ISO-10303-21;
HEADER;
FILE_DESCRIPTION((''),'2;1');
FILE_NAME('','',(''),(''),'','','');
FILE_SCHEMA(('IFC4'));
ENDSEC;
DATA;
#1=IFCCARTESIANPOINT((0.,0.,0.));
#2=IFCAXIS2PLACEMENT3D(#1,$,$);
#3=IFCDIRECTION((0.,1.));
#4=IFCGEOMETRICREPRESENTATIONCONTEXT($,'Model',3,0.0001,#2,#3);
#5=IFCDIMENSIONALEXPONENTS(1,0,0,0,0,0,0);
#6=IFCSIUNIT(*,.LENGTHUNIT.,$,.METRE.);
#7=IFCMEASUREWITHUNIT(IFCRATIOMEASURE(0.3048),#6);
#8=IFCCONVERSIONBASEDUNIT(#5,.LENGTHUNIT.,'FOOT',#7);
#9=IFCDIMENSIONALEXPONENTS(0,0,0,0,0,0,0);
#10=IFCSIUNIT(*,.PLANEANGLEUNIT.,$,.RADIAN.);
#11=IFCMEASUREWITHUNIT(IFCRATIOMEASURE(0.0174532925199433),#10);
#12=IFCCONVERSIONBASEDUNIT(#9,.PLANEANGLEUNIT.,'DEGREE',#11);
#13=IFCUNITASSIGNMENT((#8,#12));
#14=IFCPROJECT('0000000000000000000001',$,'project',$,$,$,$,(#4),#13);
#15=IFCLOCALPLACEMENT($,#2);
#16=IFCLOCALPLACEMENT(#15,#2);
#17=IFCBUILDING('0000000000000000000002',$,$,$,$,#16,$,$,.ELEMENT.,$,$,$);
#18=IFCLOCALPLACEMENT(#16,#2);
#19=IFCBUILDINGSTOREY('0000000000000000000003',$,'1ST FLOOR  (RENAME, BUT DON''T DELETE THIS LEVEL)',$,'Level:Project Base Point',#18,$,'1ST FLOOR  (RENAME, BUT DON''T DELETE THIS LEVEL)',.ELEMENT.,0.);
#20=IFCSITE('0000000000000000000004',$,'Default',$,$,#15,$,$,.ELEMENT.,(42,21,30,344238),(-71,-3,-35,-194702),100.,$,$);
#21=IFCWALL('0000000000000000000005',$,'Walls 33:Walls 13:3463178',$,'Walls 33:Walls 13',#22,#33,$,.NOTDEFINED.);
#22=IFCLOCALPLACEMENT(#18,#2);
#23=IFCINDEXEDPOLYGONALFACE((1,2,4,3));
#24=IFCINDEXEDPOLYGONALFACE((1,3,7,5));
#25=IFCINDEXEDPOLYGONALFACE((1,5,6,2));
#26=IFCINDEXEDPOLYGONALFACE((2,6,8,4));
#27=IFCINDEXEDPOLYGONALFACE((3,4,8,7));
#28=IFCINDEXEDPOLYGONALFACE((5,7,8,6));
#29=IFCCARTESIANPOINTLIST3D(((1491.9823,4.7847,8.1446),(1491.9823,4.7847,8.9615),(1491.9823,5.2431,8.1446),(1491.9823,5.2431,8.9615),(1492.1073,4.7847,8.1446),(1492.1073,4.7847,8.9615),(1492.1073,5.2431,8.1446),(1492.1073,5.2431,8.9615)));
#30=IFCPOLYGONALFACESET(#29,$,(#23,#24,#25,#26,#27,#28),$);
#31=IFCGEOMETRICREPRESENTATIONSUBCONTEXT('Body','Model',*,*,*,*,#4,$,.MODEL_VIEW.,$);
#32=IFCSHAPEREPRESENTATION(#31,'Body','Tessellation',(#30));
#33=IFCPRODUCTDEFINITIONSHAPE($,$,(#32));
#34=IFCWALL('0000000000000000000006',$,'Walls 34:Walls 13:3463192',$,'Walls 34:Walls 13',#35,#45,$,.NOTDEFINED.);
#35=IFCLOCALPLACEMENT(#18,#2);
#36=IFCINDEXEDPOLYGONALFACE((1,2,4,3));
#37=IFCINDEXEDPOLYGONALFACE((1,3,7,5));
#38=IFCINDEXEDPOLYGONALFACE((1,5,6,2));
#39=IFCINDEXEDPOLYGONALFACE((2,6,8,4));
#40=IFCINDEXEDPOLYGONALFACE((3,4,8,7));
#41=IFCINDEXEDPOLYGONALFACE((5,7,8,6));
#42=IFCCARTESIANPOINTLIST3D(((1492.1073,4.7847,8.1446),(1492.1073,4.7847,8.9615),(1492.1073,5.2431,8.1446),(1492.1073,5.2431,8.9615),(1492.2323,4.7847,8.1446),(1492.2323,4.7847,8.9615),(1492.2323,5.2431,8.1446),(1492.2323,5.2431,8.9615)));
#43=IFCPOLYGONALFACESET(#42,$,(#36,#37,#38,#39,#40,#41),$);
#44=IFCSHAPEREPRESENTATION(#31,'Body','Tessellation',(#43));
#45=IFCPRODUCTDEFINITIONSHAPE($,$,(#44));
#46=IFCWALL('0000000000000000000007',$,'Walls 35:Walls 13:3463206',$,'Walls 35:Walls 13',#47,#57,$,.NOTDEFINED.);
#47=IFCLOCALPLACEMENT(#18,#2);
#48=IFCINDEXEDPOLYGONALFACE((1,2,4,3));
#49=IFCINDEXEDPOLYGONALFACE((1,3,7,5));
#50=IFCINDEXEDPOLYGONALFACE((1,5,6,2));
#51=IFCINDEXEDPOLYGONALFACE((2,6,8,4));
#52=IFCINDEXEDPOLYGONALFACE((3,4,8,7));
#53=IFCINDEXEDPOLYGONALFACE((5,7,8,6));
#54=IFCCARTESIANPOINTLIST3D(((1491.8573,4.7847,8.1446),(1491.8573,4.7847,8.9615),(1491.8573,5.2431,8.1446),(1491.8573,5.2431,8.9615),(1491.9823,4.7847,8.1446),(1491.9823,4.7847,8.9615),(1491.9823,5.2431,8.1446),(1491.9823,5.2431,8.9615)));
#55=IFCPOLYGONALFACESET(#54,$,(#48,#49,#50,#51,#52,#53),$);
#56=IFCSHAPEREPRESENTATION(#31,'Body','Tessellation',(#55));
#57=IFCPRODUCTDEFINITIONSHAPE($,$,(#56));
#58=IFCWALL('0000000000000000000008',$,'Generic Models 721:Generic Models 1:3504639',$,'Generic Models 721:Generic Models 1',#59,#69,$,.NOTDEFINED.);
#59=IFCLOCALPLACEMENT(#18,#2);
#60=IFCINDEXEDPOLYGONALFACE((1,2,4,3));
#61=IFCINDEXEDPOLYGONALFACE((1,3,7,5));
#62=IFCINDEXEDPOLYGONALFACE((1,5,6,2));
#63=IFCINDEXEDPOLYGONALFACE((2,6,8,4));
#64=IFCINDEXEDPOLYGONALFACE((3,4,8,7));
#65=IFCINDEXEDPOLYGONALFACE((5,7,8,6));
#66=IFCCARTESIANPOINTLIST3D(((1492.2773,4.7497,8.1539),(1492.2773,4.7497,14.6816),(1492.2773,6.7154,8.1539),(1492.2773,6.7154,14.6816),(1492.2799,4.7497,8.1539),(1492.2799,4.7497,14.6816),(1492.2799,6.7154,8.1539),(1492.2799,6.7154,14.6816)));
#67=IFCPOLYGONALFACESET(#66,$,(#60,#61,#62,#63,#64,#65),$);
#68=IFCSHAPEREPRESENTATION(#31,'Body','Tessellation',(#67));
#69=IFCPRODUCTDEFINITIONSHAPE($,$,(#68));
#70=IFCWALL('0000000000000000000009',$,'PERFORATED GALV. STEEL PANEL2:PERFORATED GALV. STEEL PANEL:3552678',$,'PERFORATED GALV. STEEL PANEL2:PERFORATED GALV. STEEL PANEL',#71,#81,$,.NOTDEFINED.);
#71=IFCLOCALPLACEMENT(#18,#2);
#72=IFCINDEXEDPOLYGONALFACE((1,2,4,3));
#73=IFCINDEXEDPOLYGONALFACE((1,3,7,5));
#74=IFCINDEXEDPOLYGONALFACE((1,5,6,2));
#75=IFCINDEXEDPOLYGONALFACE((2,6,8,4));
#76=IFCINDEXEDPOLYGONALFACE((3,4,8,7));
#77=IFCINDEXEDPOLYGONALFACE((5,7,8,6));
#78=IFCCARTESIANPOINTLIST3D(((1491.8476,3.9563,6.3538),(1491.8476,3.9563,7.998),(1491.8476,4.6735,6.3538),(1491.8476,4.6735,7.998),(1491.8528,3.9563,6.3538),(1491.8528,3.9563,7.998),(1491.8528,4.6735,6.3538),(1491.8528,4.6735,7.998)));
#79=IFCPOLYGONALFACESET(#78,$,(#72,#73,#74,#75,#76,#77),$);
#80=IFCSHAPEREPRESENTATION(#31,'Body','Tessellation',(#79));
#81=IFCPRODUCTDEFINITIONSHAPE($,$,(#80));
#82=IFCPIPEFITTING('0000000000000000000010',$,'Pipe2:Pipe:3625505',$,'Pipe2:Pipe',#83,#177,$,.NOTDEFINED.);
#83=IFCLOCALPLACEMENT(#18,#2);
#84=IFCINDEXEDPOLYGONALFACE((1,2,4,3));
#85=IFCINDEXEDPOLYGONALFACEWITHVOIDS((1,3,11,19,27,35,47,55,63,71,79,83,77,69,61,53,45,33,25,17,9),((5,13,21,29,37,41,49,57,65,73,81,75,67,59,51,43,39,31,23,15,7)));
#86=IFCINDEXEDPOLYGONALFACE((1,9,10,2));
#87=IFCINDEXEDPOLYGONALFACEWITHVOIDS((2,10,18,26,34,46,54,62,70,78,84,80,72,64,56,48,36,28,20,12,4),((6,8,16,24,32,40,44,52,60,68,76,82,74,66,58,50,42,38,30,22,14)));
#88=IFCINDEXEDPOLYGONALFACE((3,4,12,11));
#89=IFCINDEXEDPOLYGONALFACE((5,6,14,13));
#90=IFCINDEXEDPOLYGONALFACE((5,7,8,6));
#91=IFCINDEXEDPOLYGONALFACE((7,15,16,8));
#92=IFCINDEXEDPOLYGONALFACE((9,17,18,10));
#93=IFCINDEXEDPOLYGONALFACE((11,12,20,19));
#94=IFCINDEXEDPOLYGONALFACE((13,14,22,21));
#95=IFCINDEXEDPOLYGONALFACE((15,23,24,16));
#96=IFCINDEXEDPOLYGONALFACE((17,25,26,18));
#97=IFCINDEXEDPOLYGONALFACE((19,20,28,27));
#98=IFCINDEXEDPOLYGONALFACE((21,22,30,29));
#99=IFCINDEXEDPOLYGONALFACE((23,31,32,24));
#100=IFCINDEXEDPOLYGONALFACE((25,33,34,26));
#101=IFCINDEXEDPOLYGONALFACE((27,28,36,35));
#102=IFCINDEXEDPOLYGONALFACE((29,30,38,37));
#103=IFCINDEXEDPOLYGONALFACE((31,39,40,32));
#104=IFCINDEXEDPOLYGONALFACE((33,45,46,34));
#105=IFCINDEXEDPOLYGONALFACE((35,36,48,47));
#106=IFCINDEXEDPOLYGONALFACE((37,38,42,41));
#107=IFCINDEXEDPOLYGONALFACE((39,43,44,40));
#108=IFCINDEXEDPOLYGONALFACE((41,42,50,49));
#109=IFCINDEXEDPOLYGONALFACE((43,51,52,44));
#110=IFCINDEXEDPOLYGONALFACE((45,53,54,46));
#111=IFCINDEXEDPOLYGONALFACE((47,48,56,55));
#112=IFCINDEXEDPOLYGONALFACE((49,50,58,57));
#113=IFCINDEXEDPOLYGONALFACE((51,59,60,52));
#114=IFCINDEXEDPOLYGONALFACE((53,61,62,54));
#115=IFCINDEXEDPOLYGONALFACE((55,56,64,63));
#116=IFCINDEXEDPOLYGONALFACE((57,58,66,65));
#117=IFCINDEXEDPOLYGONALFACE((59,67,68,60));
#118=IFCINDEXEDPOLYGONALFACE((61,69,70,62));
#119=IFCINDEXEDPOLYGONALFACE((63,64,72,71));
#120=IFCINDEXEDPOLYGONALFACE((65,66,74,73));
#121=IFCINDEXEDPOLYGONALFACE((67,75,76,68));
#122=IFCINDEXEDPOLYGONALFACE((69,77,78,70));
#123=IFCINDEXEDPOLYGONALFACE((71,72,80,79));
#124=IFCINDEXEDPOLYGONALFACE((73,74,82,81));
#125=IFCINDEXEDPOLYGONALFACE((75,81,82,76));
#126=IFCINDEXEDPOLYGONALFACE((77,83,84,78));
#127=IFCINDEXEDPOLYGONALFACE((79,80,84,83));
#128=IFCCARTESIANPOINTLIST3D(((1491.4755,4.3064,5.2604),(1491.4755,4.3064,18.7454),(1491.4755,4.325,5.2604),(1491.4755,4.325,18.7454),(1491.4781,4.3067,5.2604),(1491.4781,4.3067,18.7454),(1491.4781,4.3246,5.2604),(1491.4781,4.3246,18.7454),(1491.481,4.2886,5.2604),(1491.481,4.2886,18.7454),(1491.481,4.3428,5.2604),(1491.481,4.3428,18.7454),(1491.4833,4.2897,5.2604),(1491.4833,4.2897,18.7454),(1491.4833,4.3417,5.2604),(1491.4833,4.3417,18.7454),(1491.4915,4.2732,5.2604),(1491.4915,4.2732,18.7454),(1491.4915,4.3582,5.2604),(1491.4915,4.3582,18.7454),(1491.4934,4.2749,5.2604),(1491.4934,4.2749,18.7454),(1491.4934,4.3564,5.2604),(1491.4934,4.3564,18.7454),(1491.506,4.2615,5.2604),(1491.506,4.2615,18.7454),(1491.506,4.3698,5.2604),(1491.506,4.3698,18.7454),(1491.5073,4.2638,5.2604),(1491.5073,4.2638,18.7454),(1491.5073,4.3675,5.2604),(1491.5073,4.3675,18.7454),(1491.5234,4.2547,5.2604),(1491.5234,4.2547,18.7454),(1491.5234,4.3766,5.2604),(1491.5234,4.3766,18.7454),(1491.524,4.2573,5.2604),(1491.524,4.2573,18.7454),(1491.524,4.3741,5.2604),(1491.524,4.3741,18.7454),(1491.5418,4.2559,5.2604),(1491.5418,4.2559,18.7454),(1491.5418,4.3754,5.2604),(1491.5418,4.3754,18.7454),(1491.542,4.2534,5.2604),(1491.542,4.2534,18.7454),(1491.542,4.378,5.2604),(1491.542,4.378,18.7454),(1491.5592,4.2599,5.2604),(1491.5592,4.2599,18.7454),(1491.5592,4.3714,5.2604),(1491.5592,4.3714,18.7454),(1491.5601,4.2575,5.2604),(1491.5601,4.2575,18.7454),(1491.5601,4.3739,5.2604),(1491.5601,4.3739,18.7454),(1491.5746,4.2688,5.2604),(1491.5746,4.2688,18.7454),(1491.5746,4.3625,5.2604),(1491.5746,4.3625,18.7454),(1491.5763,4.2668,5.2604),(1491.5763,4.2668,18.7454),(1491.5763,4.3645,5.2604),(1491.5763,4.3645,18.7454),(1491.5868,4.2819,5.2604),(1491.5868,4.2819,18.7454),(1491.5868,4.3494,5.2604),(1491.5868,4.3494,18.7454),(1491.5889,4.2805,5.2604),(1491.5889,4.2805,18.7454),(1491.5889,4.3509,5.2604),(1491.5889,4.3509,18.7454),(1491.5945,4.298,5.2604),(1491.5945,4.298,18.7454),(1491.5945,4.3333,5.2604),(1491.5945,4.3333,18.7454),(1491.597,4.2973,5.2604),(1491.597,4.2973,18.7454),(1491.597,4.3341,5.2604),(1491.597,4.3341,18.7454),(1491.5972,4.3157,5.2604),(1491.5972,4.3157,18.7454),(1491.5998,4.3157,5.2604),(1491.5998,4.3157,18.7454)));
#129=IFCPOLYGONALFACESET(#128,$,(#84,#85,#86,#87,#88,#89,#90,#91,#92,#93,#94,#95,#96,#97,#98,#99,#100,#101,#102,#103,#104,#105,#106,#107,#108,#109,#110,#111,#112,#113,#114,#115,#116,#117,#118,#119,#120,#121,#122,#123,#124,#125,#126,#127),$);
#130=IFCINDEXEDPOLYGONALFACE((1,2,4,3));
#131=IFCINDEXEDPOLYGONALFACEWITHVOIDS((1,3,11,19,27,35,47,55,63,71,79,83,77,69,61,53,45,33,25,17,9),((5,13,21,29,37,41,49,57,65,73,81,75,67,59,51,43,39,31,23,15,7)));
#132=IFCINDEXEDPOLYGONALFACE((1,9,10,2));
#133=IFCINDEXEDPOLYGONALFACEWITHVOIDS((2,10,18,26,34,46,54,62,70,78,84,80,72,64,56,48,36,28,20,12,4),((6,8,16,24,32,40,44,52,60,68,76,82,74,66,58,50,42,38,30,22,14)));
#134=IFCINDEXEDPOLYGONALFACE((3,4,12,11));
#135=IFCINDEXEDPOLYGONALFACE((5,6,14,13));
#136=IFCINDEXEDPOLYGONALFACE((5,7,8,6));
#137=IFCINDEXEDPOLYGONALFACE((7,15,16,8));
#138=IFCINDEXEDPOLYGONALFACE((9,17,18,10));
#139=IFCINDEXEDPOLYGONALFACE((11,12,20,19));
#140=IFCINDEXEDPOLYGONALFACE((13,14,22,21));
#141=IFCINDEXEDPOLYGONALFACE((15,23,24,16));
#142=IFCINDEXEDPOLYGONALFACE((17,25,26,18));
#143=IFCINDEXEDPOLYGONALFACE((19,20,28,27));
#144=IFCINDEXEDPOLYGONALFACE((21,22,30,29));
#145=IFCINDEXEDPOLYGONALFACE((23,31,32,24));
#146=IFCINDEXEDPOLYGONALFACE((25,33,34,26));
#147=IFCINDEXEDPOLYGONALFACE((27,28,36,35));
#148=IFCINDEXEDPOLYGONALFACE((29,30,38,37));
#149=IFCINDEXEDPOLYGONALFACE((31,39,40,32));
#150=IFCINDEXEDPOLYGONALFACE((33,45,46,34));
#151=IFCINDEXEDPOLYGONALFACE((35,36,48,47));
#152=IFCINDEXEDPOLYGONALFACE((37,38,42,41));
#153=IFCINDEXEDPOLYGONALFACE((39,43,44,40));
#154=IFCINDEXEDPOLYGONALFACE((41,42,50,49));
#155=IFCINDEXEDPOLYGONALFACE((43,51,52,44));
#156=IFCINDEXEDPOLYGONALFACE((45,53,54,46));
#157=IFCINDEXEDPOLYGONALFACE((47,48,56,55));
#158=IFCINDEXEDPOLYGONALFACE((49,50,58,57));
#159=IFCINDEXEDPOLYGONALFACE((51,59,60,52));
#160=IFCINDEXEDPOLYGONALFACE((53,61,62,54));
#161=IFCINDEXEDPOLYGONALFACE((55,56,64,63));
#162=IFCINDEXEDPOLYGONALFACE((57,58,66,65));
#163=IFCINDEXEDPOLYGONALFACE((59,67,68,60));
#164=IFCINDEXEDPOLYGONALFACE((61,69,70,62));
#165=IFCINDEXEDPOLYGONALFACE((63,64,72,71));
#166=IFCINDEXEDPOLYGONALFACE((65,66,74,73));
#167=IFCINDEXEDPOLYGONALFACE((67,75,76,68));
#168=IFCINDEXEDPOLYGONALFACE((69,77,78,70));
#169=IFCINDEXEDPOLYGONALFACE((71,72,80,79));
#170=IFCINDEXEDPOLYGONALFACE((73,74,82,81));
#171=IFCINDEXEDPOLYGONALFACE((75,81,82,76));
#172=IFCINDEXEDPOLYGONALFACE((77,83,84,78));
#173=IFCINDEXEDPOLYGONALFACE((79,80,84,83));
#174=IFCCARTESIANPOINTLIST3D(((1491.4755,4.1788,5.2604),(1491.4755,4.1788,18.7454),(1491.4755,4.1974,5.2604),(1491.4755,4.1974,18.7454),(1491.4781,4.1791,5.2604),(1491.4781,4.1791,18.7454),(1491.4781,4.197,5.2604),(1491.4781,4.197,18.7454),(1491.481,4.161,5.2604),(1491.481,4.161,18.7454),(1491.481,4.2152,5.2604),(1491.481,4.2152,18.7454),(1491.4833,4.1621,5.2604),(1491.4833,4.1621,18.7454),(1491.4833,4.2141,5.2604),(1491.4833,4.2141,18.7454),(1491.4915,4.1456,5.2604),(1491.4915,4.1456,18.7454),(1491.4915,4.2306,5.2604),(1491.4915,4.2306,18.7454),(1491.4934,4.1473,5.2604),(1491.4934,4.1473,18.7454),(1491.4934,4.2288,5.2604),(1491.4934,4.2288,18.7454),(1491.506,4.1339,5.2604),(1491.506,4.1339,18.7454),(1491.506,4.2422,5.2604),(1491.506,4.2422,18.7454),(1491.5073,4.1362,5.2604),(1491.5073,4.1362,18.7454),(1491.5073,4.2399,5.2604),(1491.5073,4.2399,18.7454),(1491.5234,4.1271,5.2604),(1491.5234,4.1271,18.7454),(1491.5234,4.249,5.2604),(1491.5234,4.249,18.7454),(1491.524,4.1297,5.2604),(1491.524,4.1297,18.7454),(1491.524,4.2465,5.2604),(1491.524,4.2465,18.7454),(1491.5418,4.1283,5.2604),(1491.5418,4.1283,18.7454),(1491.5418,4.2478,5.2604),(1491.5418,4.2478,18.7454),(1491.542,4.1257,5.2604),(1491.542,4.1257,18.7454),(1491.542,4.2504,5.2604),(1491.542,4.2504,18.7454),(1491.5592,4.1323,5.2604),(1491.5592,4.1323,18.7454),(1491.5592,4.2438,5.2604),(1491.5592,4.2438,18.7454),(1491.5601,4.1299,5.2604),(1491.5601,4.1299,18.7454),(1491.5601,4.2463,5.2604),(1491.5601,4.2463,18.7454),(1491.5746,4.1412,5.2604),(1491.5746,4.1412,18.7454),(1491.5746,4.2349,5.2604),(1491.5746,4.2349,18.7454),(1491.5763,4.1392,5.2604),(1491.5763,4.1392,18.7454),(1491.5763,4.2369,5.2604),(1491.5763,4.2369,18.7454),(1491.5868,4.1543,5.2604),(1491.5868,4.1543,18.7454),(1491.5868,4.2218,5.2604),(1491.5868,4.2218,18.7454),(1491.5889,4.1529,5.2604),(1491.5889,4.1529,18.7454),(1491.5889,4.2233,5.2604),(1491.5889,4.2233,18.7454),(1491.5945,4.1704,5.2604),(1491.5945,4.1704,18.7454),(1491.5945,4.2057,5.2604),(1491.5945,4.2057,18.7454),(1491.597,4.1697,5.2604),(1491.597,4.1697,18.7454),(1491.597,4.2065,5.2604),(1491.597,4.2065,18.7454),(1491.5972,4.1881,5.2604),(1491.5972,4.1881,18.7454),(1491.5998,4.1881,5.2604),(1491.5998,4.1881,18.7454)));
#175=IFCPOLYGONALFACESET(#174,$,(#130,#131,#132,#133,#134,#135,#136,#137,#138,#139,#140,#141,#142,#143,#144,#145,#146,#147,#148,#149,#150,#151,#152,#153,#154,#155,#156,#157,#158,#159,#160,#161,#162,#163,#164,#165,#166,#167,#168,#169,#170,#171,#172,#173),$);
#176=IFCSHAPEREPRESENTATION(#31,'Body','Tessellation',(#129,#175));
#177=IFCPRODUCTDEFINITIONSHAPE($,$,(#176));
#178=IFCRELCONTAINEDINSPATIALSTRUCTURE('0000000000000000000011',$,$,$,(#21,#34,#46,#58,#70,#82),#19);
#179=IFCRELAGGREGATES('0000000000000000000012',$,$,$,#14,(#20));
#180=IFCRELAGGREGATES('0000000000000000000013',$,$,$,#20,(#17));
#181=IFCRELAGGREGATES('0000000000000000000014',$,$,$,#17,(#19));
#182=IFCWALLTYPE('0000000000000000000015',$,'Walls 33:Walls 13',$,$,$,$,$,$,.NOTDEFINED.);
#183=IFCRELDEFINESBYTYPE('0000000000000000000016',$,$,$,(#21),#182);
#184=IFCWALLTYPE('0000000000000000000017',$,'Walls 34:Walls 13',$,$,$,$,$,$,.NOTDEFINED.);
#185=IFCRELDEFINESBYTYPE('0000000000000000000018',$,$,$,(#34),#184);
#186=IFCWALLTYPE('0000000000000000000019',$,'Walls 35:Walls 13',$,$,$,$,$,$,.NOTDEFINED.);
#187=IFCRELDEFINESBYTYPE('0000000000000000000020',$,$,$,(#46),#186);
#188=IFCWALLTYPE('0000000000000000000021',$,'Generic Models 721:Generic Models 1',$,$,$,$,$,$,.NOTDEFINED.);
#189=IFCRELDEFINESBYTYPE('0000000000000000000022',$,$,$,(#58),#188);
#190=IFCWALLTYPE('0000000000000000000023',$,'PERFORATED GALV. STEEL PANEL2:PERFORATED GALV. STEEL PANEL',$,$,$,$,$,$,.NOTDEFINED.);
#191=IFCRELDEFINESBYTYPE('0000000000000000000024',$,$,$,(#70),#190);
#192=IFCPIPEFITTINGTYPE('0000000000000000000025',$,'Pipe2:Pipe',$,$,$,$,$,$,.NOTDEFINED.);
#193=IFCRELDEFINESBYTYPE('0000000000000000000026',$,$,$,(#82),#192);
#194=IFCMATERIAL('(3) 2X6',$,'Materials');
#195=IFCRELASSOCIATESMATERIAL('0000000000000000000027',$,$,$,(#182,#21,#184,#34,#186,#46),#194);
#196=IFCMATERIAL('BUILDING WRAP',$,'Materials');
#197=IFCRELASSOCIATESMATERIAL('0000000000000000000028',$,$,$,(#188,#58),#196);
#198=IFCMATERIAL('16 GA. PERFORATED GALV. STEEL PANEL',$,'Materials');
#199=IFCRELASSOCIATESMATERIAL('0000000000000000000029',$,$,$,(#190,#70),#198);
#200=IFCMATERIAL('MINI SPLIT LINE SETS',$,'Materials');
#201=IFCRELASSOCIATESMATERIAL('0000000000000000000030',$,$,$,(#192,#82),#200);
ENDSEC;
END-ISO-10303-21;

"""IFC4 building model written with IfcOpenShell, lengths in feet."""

from ifc_helpers import new_model, entity, si_unit, converted_unit, direction, frame, frame_2d, origin, origin_2d_with_axis, place, context, subcontext, project, spatial, rectangle, hollow_circle, extrude, source, transform, mapped, material, type_object, type_shapes, element, save


model = new_model("IFC4")

# Units and contexts
model_context = context("Model", 3, precision=0.0001, world=origin(), true_north=direction((0.0, 1.0)))
body_context = subcontext(model_context, "Body", "Model", "MODEL_VIEW")
ifc_project = project(units=[converted_unit("LENGTHUNIT", "FOOT", entity("IfcRatioMeasure", 0.3048), si_unit("LENGTHUNIT", "METRE"), dimensions=[1, 0, 0, 0, 0, 0, 0]), converted_unit("PLANEANGLEUNIT", "DEGREE", entity("IfcRatioMeasure", 0.0174532925199433), si_unit("PLANEANGLEUNIT", "RADIAN"), dimensions=[0, 0, 0, 0, 0, 0, 0])], contexts=[model_context])

# Site, building, storey
site_placement = place(None, origin())
site = spatial("IfcSite", under=ifc_project, at=site_placement, Name="Default", CompositionType="ELEMENT", RefLatitude=(42, 21, 30, 344238), RefLongitude=(-71, -3, -35, -194702), RefElevation=100.0)
building_placement = place(site_placement, origin())
building = spatial("IfcBuilding", under=site, at=building_placement, CompositionType="ELEMENT")
storey_placement = place(building_placement, origin())
storey = spatial("IfcBuildingStorey", under=building, at=storey_placement, Name="1ST FLOOR  (RENAME, BUT DON'T DELETE THIS LEVEL)", ObjectType="Level:Project Base Point", LongName="1ST FLOOR  (RENAME, BUT DON'T DELETE THIS LEVEL)", CompositionType="ELEMENT", Elevation=0.0)

# Walls
ifc_material_1 = material(Name="(3) 2X6", Category="Materials")
wall_type_1 = type_object("IfcWallType", Name="Walls 33:Walls 13", PredefinedType="NOTDEFINED", material=ifc_material_1)
wall_1_placement = place(storey_placement, frame((1491.9823, 4.7847, 8.1446), z_axis=(0.0, 0.0, 1.0), x_axis=(0.0, 1.0, 0.0)))
element("IfcWall", 1, at=wall_1_placement, inside=storey, type_object=wall_type_1, material=ifc_material_1, Name="Walls 33:Walls 13:3463178", ObjectType="Walls 33:Walls 13", PredefinedType="NOTDEFINED", context=body_context, shape_type="SweptSolid", body=[
    extrude(rectangle(XDim=0.4583, YDim=0.125, at=origin_2d_with_axis()), frame((0.2292, -0.0625, 0.0)), (0.0, 0.0, 1.0), 0.8169),
])
wall_type_2 = type_object("IfcWallType", Name="Walls 34:Walls 13", PredefinedType="NOTDEFINED", material=ifc_material_1)
wall_2_placement = place(storey_placement, frame((1492.1073, 4.7847, 8.1446), z_axis=(0.0, 0.0, 1.0), x_axis=(0.0, 1.0, 0.0)))
element("IfcWall", 2, at=wall_2_placement, inside=storey, type_object=wall_type_2, material=ifc_material_1, Name="Walls 34:Walls 13:3463192", ObjectType="Walls 34:Walls 13", PredefinedType="NOTDEFINED", context=body_context, shape_type="SweptSolid", body=[
    extrude(rectangle(XDim=0.4583, YDim=0.125, at=origin_2d_with_axis()), frame((0.2292, -0.0625, 0.0)), (0.0, 0.0, 1.0), 0.8169),
])
wall_type_3 = type_object("IfcWallType", Name="Walls 35:Walls 13", PredefinedType="NOTDEFINED", material=ifc_material_1)
wall_3_placement = place(storey_placement, frame((1491.8573, 4.7847, 8.1446), z_axis=(0.0, 0.0, 1.0), x_axis=(0.0, 1.0, 0.0)))
element("IfcWall", 3, at=wall_3_placement, inside=storey, type_object=wall_type_3, material=ifc_material_1, Name="Walls 35:Walls 13:3463206", ObjectType="Walls 35:Walls 13", PredefinedType="NOTDEFINED", context=body_context, shape_type="SweptSolid", body=[
    extrude(rectangle(XDim=0.4583, YDim=0.125, at=origin_2d_with_axis()), frame((0.2292, -0.0625, 0.0)), (0.0, 0.0, 1.0), 0.8169),
])
ifc_material_2 = material(Name="BUILDING WRAP", Category="Materials")
wall_type_4 = type_object("IfcWallType", Name="Generic Models 721:Generic Models 1", PredefinedType="NOTDEFINED", material=ifc_material_2)
wall_4_placement = place(storey_placement, frame((1492.2773, 4.7497, 8.1539), z_axis=(0.0, 0.0, 1.0), x_axis=(0.0, 1.0, 0.0)))
element("IfcWall", 4, at=wall_4_placement, inside=storey, type_object=wall_type_4, material=ifc_material_2, Name="Generic Models 721:Generic Models 1:3504639", ObjectType="Generic Models 721:Generic Models 1", PredefinedType="NOTDEFINED", context=body_context, shape_type="SweptSolid", body=[
    extrude(rectangle(XDim=0.0026, YDim=1.9656, at=origin_2d_with_axis()), frame((0.9828, -0.0013, 0.0), z_axis=(0.0, 0.0, 1.0), x_axis=(0.0, -1.0, 0.0)), (0.0, 0.0, 1.0), 6.5278),
])
ifc_material_3 = material(Name="16 GA. PERFORATED GALV. STEEL PANEL", Category="Materials")
wall_type_5 = type_object("IfcWallType", Name="PERFORATED GALV. STEEL PANEL2:PERFORATED GALV. STEEL PANEL", PredefinedType="NOTDEFINED", material=ifc_material_3)
wall_5_placement = place(storey_placement, frame((1491.8476, 3.9563, 6.3538), z_axis=(0.0, 0.0, 1.0), x_axis=(0.0, 1.0, 0.0)))
element("IfcWall", 5, at=wall_5_placement, inside=storey, type_object=wall_type_5, material=ifc_material_3, Name="PERFORATED GALV. STEEL PANEL2:PERFORATED GALV. STEEL PANEL:3552678", ObjectType="PERFORATED GALV. STEEL PANEL2:PERFORATED GALV. STEEL PANEL", PredefinedType="NOTDEFINED", context=body_context, shape_type="SweptSolid", body=[
    extrude(rectangle(XDim=0.7172, YDim=0.0052, at=frame_2d((0.0, 0.0), x_axis=(1.0, 0.0))), frame((0.3586, -0.0026, 0.0), z_axis=(0.0, 0.0, 1.0), x_axis=(-1.0, 0.0, 0.0)), (0.0, 0.0, 1.0), 1.6442),
])

# Pipe fitting
ifc_material_4 = material(Name="MINI SPLIT LINE SETS", Category="Materials")
pipe_fitting_type_1 = type_object("IfcPipeFittingType", Name="Pipe2:Pipe", PredefinedType="NOTDEFINED", material=ifc_material_4)
shared_shape_1 = source(origin(), body_context, "Body", "SweptSolid", [
    extrude(hollow_circle(Radius=0.0625, WallThickness=0.0026, at=origin_2d_with_axis()), frame((0.0677, 0.1953, 0.0)), (0.0, 0.0, 1.0), 13.485),
    extrude(hollow_circle(Radius=0.0625, WallThickness=0.0026, at=origin_2d_with_axis()), frame((0.0677, 0.0677, 0.0)), (0.0, 0.0, 1.0), 13.485),
])
type_shapes(pipe_fitting_type_1, [shared_shape_1])
pipe_fitting_1_placement = place(storey_placement, frame((1491.4696, 4.1203, 5.2604)))
element("IfcPipeFitting", 6, at=pipe_fitting_1_placement, inside=storey, type_object=pipe_fitting_type_1, material=ifc_material_4, Name="Pipe2:Pipe:3625505", ObjectType="Pipe2:Pipe", PredefinedType="NOTDEFINED", context=body_context, shape_type="MappedRepresentation", body=[
    mapped(shared_shape_1, transform((0.0, 0.0, 0.0), scale=1.0)),
])

save(model, "model.ifc")
